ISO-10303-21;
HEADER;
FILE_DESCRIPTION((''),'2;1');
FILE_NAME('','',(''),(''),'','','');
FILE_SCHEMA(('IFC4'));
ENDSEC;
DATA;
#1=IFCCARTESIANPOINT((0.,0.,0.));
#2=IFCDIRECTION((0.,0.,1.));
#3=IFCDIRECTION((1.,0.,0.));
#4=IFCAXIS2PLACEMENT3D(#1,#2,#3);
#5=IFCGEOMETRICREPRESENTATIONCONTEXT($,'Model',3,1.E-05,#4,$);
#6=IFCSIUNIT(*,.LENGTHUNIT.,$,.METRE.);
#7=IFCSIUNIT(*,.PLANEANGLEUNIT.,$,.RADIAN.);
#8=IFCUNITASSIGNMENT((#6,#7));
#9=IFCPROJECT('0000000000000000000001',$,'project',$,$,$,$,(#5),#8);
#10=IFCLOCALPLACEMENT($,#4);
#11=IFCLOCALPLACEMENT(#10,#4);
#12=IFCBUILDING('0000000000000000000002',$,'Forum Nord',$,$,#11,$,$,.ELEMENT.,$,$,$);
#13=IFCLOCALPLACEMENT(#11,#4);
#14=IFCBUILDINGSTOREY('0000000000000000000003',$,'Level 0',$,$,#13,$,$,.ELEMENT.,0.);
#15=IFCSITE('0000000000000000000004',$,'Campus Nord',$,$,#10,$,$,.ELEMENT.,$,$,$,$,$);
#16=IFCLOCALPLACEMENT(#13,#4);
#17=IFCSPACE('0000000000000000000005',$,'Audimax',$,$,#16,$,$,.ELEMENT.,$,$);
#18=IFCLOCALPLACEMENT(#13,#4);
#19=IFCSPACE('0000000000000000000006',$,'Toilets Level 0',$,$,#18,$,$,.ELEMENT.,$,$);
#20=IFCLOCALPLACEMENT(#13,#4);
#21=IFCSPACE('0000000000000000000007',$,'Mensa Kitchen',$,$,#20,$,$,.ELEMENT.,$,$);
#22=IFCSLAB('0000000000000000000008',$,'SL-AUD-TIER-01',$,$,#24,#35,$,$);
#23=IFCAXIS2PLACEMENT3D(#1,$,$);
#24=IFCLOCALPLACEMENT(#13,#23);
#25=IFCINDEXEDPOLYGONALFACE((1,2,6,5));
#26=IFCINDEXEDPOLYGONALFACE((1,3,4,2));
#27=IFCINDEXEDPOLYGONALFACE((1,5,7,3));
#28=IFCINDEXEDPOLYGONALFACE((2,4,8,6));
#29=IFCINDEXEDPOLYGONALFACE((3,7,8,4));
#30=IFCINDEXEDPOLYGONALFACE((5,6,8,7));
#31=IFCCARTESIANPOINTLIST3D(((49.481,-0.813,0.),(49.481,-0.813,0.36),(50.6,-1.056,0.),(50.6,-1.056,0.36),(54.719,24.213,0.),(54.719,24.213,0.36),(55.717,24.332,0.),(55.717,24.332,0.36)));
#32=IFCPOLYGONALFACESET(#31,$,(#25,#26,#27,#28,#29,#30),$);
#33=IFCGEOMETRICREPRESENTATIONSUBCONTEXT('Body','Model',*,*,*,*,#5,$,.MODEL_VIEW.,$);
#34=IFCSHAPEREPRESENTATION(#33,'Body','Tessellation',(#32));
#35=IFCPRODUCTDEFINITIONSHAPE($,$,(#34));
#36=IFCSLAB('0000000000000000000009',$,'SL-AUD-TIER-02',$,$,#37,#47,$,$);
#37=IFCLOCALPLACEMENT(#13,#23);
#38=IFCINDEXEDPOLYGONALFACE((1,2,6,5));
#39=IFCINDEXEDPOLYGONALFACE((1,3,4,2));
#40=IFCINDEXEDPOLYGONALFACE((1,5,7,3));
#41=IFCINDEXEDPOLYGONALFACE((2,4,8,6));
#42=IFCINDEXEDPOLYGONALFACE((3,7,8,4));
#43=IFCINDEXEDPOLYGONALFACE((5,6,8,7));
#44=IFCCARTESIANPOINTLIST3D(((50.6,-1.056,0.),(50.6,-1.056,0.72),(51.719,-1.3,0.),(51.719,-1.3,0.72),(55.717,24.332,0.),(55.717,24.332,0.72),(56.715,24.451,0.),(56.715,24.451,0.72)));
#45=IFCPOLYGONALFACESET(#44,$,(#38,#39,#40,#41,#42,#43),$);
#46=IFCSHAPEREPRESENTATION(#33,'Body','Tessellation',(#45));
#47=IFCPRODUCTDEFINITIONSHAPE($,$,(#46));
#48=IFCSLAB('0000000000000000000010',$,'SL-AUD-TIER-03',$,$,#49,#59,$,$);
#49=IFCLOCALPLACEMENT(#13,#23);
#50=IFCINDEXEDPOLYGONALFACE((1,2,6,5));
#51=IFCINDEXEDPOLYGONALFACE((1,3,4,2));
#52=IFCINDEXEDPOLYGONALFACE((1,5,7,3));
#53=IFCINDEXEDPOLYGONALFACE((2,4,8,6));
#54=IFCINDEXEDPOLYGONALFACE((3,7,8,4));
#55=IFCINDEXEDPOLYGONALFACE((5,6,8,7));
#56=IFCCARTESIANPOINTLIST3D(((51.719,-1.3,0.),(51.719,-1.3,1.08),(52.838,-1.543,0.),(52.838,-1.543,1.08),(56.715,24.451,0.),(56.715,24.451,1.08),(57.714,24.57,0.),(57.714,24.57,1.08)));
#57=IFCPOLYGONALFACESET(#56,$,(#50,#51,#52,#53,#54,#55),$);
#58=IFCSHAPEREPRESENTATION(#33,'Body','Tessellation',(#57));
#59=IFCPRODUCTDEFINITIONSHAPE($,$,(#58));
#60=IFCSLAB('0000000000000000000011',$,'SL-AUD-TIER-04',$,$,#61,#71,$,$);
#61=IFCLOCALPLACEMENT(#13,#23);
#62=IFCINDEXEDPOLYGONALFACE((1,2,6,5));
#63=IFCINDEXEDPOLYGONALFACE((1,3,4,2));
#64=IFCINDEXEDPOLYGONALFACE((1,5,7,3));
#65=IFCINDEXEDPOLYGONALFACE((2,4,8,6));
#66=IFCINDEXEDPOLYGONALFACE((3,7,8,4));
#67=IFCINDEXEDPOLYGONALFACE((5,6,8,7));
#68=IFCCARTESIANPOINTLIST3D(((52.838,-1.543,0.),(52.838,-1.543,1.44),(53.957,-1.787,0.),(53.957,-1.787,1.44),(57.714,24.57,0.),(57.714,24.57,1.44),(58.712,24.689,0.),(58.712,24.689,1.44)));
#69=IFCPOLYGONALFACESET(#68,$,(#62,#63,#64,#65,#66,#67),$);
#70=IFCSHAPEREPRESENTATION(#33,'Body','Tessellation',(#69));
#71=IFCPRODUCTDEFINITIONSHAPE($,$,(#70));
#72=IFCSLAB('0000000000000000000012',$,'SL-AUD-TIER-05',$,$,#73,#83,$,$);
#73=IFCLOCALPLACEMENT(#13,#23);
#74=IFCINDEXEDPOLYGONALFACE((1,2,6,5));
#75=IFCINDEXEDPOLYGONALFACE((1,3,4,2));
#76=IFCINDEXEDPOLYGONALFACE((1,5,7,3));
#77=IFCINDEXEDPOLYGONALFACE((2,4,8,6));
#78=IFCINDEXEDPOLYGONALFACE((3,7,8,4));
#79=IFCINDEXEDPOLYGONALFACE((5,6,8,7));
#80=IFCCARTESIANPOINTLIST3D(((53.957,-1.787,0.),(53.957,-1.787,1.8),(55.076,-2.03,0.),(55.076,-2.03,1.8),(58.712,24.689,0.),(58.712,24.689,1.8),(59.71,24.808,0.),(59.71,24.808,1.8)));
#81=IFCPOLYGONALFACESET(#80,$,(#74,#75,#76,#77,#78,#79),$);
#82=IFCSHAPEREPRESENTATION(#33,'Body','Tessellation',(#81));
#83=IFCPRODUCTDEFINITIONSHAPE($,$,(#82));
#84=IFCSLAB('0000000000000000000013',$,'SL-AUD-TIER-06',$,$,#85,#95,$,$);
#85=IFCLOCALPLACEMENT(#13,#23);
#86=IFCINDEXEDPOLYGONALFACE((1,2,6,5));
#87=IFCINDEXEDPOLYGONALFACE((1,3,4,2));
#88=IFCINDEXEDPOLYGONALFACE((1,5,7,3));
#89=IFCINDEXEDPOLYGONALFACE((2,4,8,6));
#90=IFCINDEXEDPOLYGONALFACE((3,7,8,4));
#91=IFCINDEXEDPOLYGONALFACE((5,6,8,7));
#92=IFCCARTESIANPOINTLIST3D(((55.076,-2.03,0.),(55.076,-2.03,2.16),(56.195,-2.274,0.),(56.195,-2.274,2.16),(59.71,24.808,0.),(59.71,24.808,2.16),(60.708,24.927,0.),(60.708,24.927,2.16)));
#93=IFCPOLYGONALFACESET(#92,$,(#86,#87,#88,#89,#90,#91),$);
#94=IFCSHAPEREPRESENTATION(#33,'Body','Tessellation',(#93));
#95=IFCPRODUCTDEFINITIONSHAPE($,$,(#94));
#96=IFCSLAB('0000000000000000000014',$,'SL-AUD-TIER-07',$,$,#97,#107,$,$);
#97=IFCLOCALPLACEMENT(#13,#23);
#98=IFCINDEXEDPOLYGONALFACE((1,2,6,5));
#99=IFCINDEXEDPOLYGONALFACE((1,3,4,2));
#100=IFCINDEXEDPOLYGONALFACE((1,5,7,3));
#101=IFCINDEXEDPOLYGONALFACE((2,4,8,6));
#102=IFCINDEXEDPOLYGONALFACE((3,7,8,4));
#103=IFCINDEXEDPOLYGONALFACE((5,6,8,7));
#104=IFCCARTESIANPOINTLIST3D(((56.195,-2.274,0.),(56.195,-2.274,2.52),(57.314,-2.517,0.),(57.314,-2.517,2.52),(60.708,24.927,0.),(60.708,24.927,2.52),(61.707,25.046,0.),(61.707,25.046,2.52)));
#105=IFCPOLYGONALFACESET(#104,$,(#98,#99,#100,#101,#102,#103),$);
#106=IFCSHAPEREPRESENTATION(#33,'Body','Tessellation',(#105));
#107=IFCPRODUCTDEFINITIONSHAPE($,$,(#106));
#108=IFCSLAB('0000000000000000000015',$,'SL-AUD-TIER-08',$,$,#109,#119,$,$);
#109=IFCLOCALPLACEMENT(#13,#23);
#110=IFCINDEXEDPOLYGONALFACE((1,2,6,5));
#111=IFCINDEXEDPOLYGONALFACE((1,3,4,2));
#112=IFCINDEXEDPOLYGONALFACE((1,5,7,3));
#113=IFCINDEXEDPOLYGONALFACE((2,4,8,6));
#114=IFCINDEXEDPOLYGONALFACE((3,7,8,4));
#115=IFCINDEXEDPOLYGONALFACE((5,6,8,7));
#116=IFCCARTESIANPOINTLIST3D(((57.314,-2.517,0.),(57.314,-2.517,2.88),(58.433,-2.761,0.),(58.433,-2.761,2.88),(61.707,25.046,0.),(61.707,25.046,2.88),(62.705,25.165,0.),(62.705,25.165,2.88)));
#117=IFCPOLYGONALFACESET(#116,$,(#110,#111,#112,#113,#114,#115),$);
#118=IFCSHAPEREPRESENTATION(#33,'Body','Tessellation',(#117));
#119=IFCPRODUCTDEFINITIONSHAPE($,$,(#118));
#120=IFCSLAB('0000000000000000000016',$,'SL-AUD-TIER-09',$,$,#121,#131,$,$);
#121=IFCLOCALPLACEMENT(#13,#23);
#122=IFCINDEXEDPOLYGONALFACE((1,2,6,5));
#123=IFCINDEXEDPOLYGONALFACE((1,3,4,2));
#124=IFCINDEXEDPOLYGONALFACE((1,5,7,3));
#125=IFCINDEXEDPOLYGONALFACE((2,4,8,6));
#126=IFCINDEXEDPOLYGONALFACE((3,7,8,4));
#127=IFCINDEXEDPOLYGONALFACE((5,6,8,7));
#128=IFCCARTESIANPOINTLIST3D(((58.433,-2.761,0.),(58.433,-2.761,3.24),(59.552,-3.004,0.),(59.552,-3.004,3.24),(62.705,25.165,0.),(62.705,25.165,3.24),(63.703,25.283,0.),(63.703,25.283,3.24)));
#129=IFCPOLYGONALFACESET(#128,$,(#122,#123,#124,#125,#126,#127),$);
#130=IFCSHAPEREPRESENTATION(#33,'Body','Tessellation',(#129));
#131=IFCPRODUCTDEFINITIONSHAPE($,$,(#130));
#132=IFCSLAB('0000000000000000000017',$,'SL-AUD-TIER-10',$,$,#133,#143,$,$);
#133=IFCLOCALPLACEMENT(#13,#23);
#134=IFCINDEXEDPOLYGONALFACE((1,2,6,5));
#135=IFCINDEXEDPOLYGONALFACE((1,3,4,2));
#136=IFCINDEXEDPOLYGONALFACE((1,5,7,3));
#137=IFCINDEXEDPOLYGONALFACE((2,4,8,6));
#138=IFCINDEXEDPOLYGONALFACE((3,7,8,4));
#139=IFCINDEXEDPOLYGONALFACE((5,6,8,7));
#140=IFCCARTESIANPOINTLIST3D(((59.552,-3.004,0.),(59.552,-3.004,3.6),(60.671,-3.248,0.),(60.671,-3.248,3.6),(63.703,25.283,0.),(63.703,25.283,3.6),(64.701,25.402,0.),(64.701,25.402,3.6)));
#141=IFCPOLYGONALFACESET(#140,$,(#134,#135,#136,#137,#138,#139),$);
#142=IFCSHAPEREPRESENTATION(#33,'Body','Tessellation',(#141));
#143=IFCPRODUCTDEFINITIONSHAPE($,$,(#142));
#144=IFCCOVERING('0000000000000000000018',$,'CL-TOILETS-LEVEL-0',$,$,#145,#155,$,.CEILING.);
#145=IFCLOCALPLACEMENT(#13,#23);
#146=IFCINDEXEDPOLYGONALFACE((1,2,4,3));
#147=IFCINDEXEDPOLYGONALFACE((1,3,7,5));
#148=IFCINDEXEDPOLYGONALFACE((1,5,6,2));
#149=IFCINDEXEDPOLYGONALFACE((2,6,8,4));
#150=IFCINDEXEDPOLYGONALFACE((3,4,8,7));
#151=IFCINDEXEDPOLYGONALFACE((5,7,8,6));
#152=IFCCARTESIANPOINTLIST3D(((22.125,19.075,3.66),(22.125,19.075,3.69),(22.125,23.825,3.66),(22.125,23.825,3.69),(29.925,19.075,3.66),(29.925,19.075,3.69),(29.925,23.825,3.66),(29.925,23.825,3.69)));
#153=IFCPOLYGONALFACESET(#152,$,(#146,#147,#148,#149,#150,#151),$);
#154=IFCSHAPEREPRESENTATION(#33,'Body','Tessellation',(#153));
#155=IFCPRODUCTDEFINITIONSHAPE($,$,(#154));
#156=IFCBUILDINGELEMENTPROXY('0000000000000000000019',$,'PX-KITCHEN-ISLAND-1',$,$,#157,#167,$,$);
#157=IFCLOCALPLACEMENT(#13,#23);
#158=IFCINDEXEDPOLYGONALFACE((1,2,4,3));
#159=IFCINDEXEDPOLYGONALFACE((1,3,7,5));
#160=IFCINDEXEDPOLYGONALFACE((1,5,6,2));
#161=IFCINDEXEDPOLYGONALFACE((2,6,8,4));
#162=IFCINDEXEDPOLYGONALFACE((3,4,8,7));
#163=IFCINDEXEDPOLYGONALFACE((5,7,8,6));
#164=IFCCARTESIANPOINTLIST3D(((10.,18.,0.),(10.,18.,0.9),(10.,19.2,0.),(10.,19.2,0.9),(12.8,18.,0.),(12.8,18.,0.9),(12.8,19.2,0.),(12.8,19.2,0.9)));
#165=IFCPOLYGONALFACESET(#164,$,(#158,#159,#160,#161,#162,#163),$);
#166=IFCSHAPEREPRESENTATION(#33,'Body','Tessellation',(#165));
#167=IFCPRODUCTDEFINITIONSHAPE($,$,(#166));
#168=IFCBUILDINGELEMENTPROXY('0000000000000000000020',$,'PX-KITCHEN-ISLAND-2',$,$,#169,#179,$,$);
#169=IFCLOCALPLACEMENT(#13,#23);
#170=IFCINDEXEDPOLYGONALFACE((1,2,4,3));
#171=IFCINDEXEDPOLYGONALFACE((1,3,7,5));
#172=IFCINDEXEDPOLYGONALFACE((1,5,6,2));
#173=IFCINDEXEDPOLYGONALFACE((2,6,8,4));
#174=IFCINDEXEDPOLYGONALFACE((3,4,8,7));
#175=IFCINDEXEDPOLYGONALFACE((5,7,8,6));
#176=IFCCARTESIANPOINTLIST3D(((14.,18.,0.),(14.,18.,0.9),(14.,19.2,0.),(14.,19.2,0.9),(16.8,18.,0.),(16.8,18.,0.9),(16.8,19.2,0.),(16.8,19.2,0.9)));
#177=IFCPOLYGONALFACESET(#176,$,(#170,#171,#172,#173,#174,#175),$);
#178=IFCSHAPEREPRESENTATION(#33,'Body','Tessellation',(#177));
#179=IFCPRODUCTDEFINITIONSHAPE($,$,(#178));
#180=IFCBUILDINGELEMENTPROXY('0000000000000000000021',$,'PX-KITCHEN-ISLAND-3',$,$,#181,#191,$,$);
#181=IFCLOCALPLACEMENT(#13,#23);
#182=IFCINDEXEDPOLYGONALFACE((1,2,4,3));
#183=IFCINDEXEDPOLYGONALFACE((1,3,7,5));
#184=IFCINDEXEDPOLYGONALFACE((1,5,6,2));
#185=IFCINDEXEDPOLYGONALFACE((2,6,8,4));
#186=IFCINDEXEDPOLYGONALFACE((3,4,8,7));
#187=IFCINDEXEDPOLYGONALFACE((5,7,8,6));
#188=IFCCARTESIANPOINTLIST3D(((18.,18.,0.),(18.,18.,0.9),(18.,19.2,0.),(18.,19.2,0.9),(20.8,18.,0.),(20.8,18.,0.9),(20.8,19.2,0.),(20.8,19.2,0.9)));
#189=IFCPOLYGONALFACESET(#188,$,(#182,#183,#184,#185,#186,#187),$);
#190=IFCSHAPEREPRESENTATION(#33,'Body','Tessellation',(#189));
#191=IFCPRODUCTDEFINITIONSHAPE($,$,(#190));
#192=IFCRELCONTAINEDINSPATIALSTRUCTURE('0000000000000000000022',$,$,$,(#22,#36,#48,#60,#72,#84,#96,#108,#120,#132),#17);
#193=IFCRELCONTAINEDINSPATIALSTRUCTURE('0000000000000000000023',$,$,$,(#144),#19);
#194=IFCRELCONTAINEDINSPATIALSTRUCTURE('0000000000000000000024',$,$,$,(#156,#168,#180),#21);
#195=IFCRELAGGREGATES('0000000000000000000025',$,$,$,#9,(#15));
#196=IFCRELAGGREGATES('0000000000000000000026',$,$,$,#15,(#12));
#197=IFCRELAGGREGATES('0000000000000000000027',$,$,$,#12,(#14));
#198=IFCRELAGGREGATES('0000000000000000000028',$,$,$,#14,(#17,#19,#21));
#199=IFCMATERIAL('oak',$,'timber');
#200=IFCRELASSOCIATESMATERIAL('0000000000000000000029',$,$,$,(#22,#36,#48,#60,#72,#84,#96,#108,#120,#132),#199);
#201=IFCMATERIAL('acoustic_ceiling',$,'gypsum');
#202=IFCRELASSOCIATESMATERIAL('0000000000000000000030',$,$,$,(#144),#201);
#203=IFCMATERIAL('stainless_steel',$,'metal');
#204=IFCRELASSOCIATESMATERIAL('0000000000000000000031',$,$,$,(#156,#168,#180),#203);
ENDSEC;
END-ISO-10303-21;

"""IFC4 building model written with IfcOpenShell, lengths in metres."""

from ifc_helpers import new_model, si_unit, frame, origin_with_axes, place, context, subcontext, project, spatial, polyline, outline, extrude, material, element, save


model = new_model("IFC4")

# Units and contexts
model_context = context("Model", 3, precision=1e-05, world=origin_with_axes())
body_context = subcontext(model_context, "Body", "Model", "MODEL_VIEW")
ifc_project = project(units=[si_unit("LENGTHUNIT", "METRE"), si_unit("PLANEANGLEUNIT", "RADIAN")], contexts=[model_context])

# Site, building, storey, space
site_placement = place(None, origin_with_axes())
site = spatial("IfcSite", under=ifc_project, at=site_placement, Name="Campus Nord", CompositionType="ELEMENT")
building_placement = place(site_placement, origin_with_axes())
building = spatial("IfcBuilding", under=site, at=building_placement, Name="Forum Nord", CompositionType="ELEMENT")
storey_placement = place(building_placement, origin_with_axes())
storey = spatial("IfcBuildingStorey", under=building, at=storey_placement, Name="Level 0", CompositionType="ELEMENT", Elevation=0.0)
space_1_placement = place(storey_placement, origin_with_axes())
space_1 = spatial("IfcSpace", under=storey, at=space_1_placement, Name="Audimax", CompositionType="ELEMENT")

# Slabs
ifc_material_1 = material(Name="oak", Category="timber")
slab_1_placement = place(storey_placement, frame((0.0, 0.0, 0.36), z_axis=(0.0, 0.0, 1.0), x_axis=(1.0, 0.0, 0.0)))
element("IfcSlab", 1, at=slab_1_placement, inside=space_1, material=ifc_material_1, Name="SL-AUD-TIER-01", context=body_context, shape_type="SweptSolid", body=[
    extrude(outline(polyline([(49.481, -0.813), (50.6, -1.056), (55.717, 24.332), (54.719, 24.213), (49.481, -0.813)])), frame((0.0, 0.0, -0.36), z_axis=(0.0, 0.0, 1.0), x_axis=(1.0, 0.0, 0.0)), (0.0, 0.0, 1.0), 0.36),
])
slab_2_placement = place(storey_placement, frame((0.0, 0.0, 0.72), z_axis=(0.0, 0.0, 1.0), x_axis=(1.0, 0.0, 0.0)))
element("IfcSlab", 2, at=slab_2_placement, inside=space_1, material=ifc_material_1, Name="SL-AUD-TIER-02", context=body_context, shape_type="SweptSolid", body=[
    extrude(outline(polyline([(50.6, -1.056), (51.719, -1.3), (56.715, 24.451), (55.717, 24.332), (50.6, -1.056)])), frame((0.0, 0.0, -0.72), z_axis=(0.0, 0.0, 1.0), x_axis=(1.0, 0.0, 0.0)), (0.0, 0.0, 1.0), 0.72),
])
slab_3_placement = place(storey_placement, frame((0.0, 0.0, 1.08), z_axis=(0.0, 0.0, 1.0), x_axis=(1.0, 0.0, 0.0)))
element("IfcSlab", 3, at=slab_3_placement, inside=space_1, material=ifc_material_1, Name="SL-AUD-TIER-03", context=body_context, shape_type="SweptSolid", body=[
    extrude(outline(polyline([(51.719, -1.3), (52.838, -1.543), (57.714, 24.57), (56.715, 24.451), (51.719, -1.3)])), frame((0.0, 0.0, -1.08), z_axis=(0.0, 0.0, 1.0), x_axis=(1.0, 0.0, 0.0)), (0.0, 0.0, 1.0), 1.08),
])
slab_4_placement = place(storey_placement, frame((0.0, 0.0, 1.44), z_axis=(0.0, 0.0, 1.0), x_axis=(1.0, 0.0, 0.0)))
element("IfcSlab", 4, at=slab_4_placement, inside=space_1, material=ifc_material_1, Name="SL-AUD-TIER-04", context=body_context, shape_type="SweptSolid", body=[
    extrude(outline(polyline([(52.838, -1.543), (53.957, -1.787), (58.712, 24.689), (57.714, 24.57), (52.838, -1.543)])), frame((0.0, 0.0, -1.44), z_axis=(0.0, 0.0, 1.0), x_axis=(1.0, 0.0, 0.0)), (0.0, 0.0, 1.0), 1.44),
])
slab_5_placement = place(storey_placement, frame((0.0, 0.0, 1.8), z_axis=(0.0, 0.0, 1.0), x_axis=(1.0, 0.0, 0.0)))
element("IfcSlab", 5, at=slab_5_placement, inside=space_1, material=ifc_material_1, Name="SL-AUD-TIER-05", context=body_context, shape_type="SweptSolid", body=[
    extrude(outline(polyline([(53.957, -1.787), (55.076, -2.03), (59.71, 24.808), (58.712, 24.689), (53.957, -1.787)])), frame((0.0, 0.0, -1.8), z_axis=(0.0, 0.0, 1.0), x_axis=(1.0, 0.0, 0.0)), (0.0, 0.0, 1.0), 1.8),
])
slab_6_placement = place(storey_placement, frame((0.0, 0.0, 2.16), z_axis=(0.0, 0.0, 1.0), x_axis=(1.0, 0.0, 0.0)))
element("IfcSlab", 6, at=slab_6_placement, inside=space_1, material=ifc_material_1, Name="SL-AUD-TIER-06", context=body_context, shape_type="SweptSolid", body=[
    extrude(outline(polyline([(55.076, -2.03), (56.195, -2.274), (60.708, 24.927), (59.71, 24.808), (55.076, -2.03)])), frame((0.0, 0.0, -2.16), z_axis=(0.0, 0.0, 1.0), x_axis=(1.0, 0.0, 0.0)), (0.0, 0.0, 1.0), 2.16),
])
slab_7_placement = place(storey_placement, frame((0.0, 0.0, 2.52), z_axis=(0.0, 0.0, 1.0), x_axis=(1.0, 0.0, 0.0)))
element("IfcSlab", 7, at=slab_7_placement, inside=space_1, material=ifc_material_1, Name="SL-AUD-TIER-07", context=body_context, shape_type="SweptSolid", body=[
    extrude(outline(polyline([(56.195, -2.274), (57.314, -2.517), (61.707, 25.046), (60.708, 24.927), (56.195, -2.274)])), frame((0.0, 0.0, -2.52), z_axis=(0.0, 0.0, 1.0), x_axis=(1.0, 0.0, 0.0)), (0.0, 0.0, 1.0), 2.52),
])
slab_8_placement = place(storey_placement, frame((0.0, 0.0, 2.88), z_axis=(0.0, 0.0, 1.0), x_axis=(1.0, 0.0, 0.0)))
element("IfcSlab", 8, at=slab_8_placement, inside=space_1, material=ifc_material_1, Name="SL-AUD-TIER-08", context=body_context, shape_type="SweptSolid", body=[
    extrude(outline(polyline([(57.314, -2.517), (58.433, -2.761), (62.705, 25.165), (61.707, 25.046), (57.314, -2.517)])), frame((0.0, 0.0, -2.88), z_axis=(0.0, 0.0, 1.0), x_axis=(1.0, 0.0, 0.0)), (0.0, 0.0, 1.0), 2.88),
])
slab_9_placement = place(storey_placement, frame((0.0, 0.0, 3.24), z_axis=(0.0, 0.0, 1.0), x_axis=(1.0, 0.0, 0.0)))
element("IfcSlab", 9, at=slab_9_placement, inside=space_1, material=ifc_material_1, Name="SL-AUD-TIER-09", context=body_context, shape_type="SweptSolid", body=[
    extrude(outline(polyline([(58.433, -2.761), (59.552, -3.004), (63.703, 25.283), (62.705, 25.165), (58.433, -2.761)])), frame((0.0, 0.0, -3.24), z_axis=(0.0, 0.0, 1.0), x_axis=(1.0, 0.0, 0.0)), (0.0, 0.0, 1.0), 3.24),
])
slab_10_placement = place(storey_placement, frame((0.0, 0.0, 3.6), z_axis=(0.0, 0.0, 1.0), x_axis=(1.0, 0.0, 0.0)))
element("IfcSlab", 10, at=slab_10_placement, inside=space_1, material=ifc_material_1, Name="SL-AUD-TIER-10", context=body_context, shape_type="SweptSolid", body=[
    extrude(outline(polyline([(59.552, -3.004), (60.671, -3.248), (64.701, 25.402), (63.703, 25.283), (59.552, -3.004)])), frame((0.0, 0.0, -3.6), z_axis=(0.0, 0.0, 1.0), x_axis=(1.0, 0.0, 0.0)), (0.0, 0.0, 1.0), 3.6),
])

# Shared definitions
space_2_placement = place(storey_placement, origin_with_axes())
space_2 = spatial("IfcSpace", under=storey, at=space_2_placement, Name="Toilets Level 0", CompositionType="ELEMENT")

# Covering
ifc_material_2 = material(Name="acoustic_ceiling", Category="gypsum")
covering_placement = place(storey_placement, frame((0.0, 0.0, 3.66), z_axis=(0.0, 0.0, 1.0), x_axis=(1.0, 0.0, 0.0)))
element("IfcCovering", 11, at=covering_placement, inside=space_2, material=ifc_material_2, Name="CL-TOILETS-LEVEL-0", PredefinedType="CEILING", context=body_context, shape_type="SweptSolid", body=[
    extrude(outline(polyline([(22.125, 23.825), (22.125, 19.075), (29.925, 19.075), (29.925, 23.825), (22.125, 23.825)])), origin_with_axes(), (0.0, 0.0, 1.0), 0.03),
])

# Shared definitions
space_3_placement = place(storey_placement, origin_with_axes())
space_3 = spatial("IfcSpace", under=storey, at=space_3_placement, Name="Mensa Kitchen", CompositionType="ELEMENT")

# Building element proxies
ifc_material_3 = material(Name="stainless_steel", Category="metal")
proxy_1_placement = place(storey_placement, origin_with_axes())
element("IfcBuildingElementProxy", 12, at=proxy_1_placement, inside=space_3, material=ifc_material_3, Name="PX-KITCHEN-ISLAND-1", context=body_context, shape_type="SweptSolid", body=[
    extrude(outline(polyline([(10.0, 18.0), (12.8, 18.0), (12.8, 19.2), (10.0, 19.2), (10.0, 18.0)])), origin_with_axes(), (0.0, 0.0, 1.0), 0.9),
])
proxy_2_placement = place(storey_placement, origin_with_axes())
element("IfcBuildingElementProxy", 13, at=proxy_2_placement, inside=space_3, material=ifc_material_3, Name="PX-KITCHEN-ISLAND-2", context=body_context, shape_type="SweptSolid", body=[
    extrude(outline(polyline([(14.0, 18.0), (16.8, 18.0), (16.8, 19.2), (14.0, 19.2), (14.0, 18.0)])), origin_with_axes(), (0.0, 0.0, 1.0), 0.9),
])
proxy_3_placement = place(storey_placement, origin_with_axes())
element("IfcBuildingElementProxy", 14, at=proxy_3_placement, inside=space_3, material=ifc_material_3, Name="PX-KITCHEN-ISLAND-3", context=body_context, shape_type="SweptSolid", body=[
    extrude(outline(polyline([(18.0, 18.0), (20.8, 18.0), (20.8, 19.2), (18.0, 19.2), (18.0, 18.0)])), origin_with_axes(), (0.0, 0.0, 1.0), 0.9),
])

save(model, "model.ifc")
